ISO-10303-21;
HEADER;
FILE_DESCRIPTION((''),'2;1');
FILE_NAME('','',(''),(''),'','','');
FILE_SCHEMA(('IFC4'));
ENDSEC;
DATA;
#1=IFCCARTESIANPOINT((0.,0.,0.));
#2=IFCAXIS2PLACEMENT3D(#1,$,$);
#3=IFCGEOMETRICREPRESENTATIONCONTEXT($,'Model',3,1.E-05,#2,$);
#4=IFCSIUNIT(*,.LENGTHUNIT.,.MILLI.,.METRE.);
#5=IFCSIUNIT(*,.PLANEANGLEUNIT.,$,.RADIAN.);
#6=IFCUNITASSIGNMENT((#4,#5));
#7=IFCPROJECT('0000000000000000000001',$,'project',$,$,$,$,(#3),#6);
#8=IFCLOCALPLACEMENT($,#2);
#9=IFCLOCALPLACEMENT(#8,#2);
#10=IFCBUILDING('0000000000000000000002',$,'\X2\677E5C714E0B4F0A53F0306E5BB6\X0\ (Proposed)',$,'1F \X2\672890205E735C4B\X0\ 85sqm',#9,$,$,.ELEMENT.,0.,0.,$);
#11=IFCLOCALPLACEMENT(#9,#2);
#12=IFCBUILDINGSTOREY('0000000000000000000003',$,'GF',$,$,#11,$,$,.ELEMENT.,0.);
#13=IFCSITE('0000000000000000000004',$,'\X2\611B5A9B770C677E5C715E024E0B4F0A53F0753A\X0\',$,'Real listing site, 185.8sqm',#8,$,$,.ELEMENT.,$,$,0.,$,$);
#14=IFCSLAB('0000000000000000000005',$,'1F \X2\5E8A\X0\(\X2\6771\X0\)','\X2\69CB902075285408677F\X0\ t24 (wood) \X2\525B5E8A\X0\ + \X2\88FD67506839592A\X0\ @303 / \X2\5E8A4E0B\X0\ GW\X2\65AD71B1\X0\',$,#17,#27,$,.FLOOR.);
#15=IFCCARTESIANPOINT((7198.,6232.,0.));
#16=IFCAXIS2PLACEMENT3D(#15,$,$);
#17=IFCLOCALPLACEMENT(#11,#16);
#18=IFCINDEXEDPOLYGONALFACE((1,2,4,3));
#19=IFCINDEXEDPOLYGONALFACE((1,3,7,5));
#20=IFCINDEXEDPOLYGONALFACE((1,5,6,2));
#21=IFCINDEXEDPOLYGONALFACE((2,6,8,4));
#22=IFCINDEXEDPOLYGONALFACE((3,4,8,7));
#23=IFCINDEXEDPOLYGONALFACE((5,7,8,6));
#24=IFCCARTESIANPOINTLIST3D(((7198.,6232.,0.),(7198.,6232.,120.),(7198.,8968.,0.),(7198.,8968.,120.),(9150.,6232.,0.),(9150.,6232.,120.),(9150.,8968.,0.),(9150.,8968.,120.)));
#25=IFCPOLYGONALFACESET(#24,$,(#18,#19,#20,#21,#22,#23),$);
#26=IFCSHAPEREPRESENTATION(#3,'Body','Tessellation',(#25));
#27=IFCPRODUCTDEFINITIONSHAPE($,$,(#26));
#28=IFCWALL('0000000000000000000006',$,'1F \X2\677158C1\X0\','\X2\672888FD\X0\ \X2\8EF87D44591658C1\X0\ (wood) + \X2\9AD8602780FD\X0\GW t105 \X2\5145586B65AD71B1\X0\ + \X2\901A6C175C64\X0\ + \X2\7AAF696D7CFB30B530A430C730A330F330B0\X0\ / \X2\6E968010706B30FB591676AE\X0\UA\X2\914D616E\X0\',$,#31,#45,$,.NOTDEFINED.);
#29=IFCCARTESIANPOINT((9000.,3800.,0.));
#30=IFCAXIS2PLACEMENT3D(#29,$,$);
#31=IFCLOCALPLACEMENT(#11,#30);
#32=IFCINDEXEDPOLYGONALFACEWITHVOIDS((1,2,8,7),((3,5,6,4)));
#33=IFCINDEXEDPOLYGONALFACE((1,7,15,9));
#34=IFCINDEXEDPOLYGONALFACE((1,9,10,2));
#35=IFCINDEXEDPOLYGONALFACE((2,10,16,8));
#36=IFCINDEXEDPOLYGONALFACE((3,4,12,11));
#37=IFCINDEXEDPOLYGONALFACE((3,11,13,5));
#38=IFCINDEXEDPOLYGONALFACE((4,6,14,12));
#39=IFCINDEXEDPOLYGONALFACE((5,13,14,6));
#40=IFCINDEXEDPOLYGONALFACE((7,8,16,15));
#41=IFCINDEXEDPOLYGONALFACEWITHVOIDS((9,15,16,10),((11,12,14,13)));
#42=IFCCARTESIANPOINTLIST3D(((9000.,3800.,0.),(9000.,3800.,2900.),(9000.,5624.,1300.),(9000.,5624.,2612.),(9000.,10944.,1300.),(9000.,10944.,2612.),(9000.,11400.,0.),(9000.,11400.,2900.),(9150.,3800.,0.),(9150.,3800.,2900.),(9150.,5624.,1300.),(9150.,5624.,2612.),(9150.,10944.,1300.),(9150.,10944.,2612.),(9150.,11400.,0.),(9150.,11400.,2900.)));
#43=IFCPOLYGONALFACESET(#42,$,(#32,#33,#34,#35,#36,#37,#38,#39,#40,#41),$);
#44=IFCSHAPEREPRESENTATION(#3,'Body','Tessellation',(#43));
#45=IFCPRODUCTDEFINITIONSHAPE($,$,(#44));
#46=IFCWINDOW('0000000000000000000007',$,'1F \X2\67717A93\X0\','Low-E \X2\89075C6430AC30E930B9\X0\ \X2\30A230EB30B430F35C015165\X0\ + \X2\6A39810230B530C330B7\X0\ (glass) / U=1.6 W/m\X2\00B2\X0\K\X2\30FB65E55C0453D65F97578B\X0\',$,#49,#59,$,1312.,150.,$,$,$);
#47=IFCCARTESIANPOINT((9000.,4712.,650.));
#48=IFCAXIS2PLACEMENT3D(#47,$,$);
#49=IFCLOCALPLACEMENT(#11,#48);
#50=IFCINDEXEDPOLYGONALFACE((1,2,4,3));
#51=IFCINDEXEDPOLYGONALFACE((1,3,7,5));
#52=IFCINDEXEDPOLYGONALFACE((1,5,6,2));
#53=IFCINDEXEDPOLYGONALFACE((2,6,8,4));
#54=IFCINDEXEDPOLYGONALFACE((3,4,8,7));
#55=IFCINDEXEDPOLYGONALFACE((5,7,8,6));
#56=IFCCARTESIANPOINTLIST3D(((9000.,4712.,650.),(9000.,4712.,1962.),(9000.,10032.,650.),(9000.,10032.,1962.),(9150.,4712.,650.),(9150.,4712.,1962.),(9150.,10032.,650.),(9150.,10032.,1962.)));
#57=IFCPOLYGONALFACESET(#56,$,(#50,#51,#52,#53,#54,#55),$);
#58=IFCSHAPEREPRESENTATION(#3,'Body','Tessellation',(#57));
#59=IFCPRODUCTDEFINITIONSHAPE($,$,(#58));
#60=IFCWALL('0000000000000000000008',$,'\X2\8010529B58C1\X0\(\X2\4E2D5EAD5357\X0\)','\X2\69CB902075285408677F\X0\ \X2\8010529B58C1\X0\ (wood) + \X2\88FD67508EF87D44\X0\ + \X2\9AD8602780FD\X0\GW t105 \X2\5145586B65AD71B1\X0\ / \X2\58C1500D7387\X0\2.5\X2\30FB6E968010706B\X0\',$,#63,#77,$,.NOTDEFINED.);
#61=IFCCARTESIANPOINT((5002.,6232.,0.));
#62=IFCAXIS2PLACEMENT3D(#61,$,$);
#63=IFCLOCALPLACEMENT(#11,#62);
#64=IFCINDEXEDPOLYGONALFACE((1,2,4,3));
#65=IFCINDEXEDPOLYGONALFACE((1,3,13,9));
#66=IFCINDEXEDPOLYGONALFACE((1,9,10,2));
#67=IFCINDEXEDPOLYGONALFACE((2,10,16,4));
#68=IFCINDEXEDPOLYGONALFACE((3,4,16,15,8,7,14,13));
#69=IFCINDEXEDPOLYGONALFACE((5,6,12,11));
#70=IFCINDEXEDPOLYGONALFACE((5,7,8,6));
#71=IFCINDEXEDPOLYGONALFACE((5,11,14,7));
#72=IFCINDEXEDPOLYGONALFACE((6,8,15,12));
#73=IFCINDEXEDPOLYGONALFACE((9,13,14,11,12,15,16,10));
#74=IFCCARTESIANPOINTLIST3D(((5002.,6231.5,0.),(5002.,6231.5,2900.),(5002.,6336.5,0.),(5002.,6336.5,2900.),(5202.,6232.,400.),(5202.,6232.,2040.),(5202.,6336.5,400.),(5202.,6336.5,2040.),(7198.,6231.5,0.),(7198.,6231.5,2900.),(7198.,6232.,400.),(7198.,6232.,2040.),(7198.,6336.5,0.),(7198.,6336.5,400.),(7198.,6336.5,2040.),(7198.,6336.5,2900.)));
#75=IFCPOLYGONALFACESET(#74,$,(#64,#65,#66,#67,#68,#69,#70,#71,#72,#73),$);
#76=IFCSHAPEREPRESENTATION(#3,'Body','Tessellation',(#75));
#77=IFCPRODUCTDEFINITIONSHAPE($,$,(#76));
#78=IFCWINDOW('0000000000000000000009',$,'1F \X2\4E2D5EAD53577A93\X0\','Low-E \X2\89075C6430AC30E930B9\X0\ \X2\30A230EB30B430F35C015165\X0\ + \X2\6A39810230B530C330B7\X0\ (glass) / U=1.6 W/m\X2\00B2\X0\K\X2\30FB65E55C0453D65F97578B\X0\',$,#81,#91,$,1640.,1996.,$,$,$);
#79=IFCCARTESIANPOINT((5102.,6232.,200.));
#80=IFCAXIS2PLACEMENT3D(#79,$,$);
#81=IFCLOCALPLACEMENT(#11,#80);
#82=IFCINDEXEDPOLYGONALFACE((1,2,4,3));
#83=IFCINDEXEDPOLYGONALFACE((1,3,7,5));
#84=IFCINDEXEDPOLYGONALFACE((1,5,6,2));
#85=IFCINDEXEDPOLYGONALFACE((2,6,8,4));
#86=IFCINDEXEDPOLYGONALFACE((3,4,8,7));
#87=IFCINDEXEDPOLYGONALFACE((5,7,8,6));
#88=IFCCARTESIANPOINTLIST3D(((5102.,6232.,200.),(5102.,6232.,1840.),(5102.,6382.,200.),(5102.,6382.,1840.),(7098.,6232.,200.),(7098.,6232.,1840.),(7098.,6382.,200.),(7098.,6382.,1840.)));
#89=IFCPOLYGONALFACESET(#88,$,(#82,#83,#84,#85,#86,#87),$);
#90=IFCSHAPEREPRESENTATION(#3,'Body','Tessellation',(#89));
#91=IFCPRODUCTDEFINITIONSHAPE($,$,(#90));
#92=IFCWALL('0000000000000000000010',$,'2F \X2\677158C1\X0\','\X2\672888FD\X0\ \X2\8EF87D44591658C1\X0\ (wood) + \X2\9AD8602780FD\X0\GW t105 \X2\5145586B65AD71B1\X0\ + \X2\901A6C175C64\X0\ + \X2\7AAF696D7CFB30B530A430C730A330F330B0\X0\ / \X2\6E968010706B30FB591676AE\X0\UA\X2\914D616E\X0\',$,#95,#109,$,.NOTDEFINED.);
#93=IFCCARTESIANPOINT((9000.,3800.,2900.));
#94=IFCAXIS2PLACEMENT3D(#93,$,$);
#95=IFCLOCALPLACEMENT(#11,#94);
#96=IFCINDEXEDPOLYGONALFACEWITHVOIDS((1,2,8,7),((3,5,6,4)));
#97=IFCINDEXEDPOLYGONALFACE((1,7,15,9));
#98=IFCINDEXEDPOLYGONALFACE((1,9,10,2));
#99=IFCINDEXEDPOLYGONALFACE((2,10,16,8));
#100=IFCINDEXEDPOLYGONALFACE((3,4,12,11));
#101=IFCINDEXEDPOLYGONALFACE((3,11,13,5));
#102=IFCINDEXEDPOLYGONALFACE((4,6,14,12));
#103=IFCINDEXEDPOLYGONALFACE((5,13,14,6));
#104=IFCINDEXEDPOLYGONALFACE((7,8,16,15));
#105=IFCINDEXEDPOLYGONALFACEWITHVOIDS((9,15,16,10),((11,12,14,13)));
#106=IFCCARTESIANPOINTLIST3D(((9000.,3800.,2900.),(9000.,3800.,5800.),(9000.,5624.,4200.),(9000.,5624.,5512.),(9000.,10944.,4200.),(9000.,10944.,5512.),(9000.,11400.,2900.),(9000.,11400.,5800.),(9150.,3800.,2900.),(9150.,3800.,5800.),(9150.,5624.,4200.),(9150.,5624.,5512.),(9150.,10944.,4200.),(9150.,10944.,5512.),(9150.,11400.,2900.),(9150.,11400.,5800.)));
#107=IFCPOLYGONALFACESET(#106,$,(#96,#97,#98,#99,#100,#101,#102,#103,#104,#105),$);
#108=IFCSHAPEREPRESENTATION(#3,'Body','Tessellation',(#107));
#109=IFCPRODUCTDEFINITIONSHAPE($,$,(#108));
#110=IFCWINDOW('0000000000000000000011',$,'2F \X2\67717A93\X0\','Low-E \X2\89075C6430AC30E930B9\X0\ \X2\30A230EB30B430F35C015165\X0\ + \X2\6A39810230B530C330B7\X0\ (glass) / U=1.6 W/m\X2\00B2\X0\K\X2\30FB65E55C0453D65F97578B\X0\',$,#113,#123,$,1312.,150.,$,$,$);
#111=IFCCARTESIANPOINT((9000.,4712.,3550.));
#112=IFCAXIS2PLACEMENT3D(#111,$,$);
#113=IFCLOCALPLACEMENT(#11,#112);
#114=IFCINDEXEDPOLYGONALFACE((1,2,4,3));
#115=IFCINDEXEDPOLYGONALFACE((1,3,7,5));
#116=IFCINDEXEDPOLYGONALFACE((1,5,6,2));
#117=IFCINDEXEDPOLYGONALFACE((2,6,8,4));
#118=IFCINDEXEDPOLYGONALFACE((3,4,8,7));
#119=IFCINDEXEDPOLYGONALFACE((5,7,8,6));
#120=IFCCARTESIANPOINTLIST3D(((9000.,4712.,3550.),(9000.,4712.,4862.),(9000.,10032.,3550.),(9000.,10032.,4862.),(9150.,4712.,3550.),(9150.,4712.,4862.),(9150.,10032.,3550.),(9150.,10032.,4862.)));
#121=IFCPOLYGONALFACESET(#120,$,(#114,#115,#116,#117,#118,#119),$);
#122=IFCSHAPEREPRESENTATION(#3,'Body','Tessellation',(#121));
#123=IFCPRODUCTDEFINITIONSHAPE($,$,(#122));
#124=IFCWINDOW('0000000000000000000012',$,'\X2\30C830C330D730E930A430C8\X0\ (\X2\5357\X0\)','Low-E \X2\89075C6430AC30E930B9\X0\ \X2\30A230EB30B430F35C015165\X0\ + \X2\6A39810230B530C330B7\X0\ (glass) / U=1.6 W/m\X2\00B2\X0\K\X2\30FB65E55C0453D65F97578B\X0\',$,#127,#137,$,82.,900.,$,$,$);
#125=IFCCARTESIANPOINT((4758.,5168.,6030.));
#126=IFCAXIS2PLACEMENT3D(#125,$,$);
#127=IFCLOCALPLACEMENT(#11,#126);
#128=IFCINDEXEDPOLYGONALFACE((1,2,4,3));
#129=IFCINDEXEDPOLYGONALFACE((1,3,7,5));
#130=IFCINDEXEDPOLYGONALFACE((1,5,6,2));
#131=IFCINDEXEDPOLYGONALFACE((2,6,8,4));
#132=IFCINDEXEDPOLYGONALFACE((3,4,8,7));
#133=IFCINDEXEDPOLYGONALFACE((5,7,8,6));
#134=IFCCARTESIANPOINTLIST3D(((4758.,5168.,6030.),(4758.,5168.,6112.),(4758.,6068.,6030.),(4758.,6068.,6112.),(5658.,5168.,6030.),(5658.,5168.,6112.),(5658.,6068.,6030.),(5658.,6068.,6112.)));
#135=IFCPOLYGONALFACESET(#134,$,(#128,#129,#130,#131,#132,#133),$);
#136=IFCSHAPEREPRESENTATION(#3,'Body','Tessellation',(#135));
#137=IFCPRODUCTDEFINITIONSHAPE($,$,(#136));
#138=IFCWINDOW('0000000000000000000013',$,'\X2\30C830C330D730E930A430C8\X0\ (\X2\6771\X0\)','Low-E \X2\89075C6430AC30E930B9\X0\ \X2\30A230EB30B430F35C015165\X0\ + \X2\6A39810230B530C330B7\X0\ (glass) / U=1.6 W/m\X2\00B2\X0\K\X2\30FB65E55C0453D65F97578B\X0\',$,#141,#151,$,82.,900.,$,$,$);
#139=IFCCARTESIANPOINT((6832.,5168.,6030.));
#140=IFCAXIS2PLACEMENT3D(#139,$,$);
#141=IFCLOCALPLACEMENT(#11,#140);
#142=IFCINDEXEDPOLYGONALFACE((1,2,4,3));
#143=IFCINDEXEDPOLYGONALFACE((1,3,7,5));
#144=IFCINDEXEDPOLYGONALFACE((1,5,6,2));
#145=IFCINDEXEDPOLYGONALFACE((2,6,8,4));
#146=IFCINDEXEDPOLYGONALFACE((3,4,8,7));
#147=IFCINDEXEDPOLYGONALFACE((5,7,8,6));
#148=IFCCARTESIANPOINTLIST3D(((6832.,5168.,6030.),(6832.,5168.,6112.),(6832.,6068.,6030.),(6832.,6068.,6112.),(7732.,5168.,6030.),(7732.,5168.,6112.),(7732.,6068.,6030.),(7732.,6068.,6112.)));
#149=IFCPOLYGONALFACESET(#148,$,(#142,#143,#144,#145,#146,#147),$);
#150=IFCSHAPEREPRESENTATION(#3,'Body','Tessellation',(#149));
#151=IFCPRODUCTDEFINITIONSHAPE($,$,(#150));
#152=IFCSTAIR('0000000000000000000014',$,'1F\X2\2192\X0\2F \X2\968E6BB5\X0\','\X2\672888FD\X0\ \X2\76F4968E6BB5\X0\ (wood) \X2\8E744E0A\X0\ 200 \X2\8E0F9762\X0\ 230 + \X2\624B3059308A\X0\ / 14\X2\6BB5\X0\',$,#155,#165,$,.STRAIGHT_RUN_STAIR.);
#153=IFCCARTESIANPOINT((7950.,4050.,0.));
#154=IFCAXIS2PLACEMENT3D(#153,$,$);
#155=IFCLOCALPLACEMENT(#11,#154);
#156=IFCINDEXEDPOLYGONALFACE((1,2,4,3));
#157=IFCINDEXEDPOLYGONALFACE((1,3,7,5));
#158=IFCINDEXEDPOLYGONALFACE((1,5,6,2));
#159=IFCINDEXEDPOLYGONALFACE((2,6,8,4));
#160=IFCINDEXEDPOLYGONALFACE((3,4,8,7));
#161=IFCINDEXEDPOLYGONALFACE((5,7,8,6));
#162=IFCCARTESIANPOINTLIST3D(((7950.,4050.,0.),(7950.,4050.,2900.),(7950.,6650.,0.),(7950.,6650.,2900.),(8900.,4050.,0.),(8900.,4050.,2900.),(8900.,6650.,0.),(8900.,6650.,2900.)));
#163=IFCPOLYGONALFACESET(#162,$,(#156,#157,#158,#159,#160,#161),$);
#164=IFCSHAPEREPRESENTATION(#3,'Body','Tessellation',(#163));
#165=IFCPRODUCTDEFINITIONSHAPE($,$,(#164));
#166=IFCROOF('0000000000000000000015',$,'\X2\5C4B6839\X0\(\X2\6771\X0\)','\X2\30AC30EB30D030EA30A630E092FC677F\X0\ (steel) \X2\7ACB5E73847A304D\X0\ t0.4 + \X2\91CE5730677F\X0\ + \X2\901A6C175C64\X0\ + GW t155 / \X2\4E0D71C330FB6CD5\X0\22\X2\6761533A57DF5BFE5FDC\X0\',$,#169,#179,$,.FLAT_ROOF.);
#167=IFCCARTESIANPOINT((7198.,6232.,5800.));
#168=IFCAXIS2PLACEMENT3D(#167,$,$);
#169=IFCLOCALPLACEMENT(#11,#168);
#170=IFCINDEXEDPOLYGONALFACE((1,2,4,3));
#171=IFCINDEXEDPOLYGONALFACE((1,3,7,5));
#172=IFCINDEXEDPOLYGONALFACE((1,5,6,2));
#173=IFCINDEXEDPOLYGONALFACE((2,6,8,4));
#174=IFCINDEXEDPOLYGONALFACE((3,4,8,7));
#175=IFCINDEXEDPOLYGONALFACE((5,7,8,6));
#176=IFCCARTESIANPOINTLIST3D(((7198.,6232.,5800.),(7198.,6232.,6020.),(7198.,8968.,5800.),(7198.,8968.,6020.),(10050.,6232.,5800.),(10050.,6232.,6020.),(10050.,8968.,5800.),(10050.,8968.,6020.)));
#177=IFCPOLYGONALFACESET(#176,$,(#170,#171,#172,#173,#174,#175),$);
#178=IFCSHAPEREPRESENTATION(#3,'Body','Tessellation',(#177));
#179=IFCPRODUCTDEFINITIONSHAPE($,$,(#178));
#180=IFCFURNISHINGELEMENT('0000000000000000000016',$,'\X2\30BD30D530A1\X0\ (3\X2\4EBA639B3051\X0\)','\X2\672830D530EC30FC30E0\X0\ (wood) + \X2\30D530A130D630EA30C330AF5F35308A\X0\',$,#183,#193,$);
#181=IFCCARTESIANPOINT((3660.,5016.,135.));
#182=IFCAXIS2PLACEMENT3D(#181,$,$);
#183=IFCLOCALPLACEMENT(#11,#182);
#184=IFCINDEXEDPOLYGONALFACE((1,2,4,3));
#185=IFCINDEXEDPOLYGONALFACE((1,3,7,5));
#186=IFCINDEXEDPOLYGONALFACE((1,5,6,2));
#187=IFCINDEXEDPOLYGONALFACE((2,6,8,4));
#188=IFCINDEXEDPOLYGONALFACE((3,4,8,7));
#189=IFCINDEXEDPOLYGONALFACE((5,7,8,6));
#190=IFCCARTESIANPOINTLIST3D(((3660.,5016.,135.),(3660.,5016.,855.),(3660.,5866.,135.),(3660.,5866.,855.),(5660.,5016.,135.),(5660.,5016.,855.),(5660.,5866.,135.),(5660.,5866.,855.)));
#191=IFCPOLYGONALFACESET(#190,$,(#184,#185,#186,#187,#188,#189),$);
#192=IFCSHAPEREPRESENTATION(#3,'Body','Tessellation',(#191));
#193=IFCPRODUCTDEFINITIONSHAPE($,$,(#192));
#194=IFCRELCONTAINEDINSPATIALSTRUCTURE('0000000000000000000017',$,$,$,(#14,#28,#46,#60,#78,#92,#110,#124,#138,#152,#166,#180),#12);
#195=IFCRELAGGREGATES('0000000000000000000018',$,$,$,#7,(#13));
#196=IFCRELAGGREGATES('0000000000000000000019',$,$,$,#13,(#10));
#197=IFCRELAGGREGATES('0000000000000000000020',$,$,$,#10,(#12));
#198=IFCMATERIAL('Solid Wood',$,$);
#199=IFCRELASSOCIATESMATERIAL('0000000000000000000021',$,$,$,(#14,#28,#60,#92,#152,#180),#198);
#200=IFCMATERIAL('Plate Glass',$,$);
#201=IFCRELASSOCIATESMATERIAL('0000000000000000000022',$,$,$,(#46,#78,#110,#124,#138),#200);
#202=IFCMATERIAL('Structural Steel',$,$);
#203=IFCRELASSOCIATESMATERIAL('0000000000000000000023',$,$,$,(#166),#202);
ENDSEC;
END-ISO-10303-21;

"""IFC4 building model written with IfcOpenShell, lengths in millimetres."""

from ifc_helpers import new_model, si_unit, frame, frame_2d, origin, place, context, project, spatial, rectangle, extrude, material, element, fill, save


model = new_model("IFC4")

# Units and contexts
model_context = context("Model", 3, precision=1e-05, world=origin())
ifc_project = project(units=[si_unit("LENGTHUNIT", "METRE", prefix="MILLI"), si_unit("PLANEANGLEUNIT", "RADIAN")], contexts=[model_context])

# Site, building, storey
site_placement = place(None, origin())
site = spatial("IfcSite", under=ifc_project, at=site_placement, Name="愛媛県松山市下伊台町", ObjectType="Real listing site, 185.8sqm", CompositionType="ELEMENT", RefElevation=0.0)
building_placement = place(site_placement, origin())
building = spatial("IfcBuilding", under=site, at=building_placement, Name="松山下伊台の家 (Proposed)", ObjectType="1F 木造平屋 85sqm", CompositionType="ELEMENT", ElevationOfRefHeight=0.0, ElevationOfTerrain=0.0)
storey_placement = place(building_placement, origin())
storey = spatial("IfcBuildingStorey", under=building, at=storey_placement, Name="GF", CompositionType="ELEMENT", Elevation=0.0)

# Slab
ifc_material_1 = material(Name="Solid Wood")
slab_placement = place(storey_placement, frame((7198.0, 6232.0, 0.0)))
element("IfcSlab", 1, at=slab_placement, inside=storey, material=ifc_material_1, Name="1F 床(東)", Description="構造用合板 t24 (wood) 剛床 + 製材根太 @303 / 床下 GW断熱", PredefinedType="FLOOR", context=model_context, shape_type="SweptSolid", body=[
    extrude(rectangle(XDim=1952.0, YDim=2736.0, at=frame_2d((976.0, 1368.0))), frame((7198.0, 6232.0, 0.0)), (0.0, 0.0, 1.0), 120.0),
])

# Walls, openings, windows
wall_1_placement = place(storey_placement, frame((9000.0, 3800.0, 0.0)))
wall_1 = element("IfcWall", 2, at=wall_1_placement, inside=storey, material=ifc_material_1, Name="1F 東壁", Description="木製 軸組外壁 (wood) + 高性能GW t105 充填断熱 + 通気層 + 窯業系サイディング / 準耐火・外皮UA配慮", PredefinedType="NOTDEFINED", context=model_context, shape_type="SweptSolid", body=[
    extrude(rectangle(XDim=150.0, YDim=7600.0, at=frame_2d((75.0, 3800.0))), frame((9000.0, 3800.0, 0.0)), (0.0, 0.0, 1.0), 2900.0),
])
opening_1_placement = place(storey_placement, frame((9000.0, 4712.0, 650.0)))
opening_1 = element("IfcOpeningElement", 3, at=opening_1_placement, cuts=wall_1, PredefinedType="NOTDEFINED", context=model_context, shape_type="SweptSolid", body=[
    extrude(rectangle(XDim=150.0, YDim=5320.0, at=frame_2d((75.0, 2660.0))), frame((9000.0, 4712.0, 650.0)), (0.0, 0.0, 1.0), 1312.0),
])
ifc_material_2 = material(Name="Plate Glass")
window_1_placement = place(storey_placement, frame((9000.0, 4712.0, 650.0)))
window_1 = element("IfcWindow", 4, at=window_1_placement, inside=storey, material=ifc_material_2, Name="1F 東窓", Description="Low-E 複層ガラス アルゴン封入 + 樹脂サッシ (glass) / U=1.6 W/m²K・日射取得型", OverallHeight=1312.0, OverallWidth=150.0, context=model_context, shape_type="SweptSolid", body=[
    extrude(rectangle(XDim=150.0, YDim=5320.0, at=frame_2d((75.0, 2660.0))), frame((9000.0, 4712.0, 650.0)), (0.0, 0.0, 1.0), 1312.0),
])
fill(opening_1, window_1)
wall_2_placement = place(storey_placement, frame((5002.0, 6232.0, 0.0)))
wall_2 = element("IfcWall", 5, at=wall_2_placement, inside=storey, material=ifc_material_1, Name="耐力壁(中庭南)", Description="構造用合板 耐力壁 (wood) + 製材軸組 + 高性能GW t105 充填断熱 / 壁倍率2.5・準耐火", PredefinedType="NOTDEFINED", context=model_context, shape_type="SweptSolid", body=[
    extrude(rectangle(XDim=2196.0, YDim=105.0, at=frame_2d((1098.0, 52.0))), frame((5002.0, 6232.0, 0.0)), (0.0, 0.0, 1.0), 2900.0),
])
opening_2_placement = place(storey_placement, frame((5102.0, 6232.0, 200.0)))
opening_2 = element("IfcOpeningElement", 6, at=opening_2_placement, cuts=wall_2, PredefinedType="NOTDEFINED", context=model_context, shape_type="SweptSolid", body=[
    extrude(rectangle(XDim=1996.0, YDim=150.0, at=frame_2d((998.0, 75.0))), frame((5102.0, 6232.0, 200.0)), (0.0, 0.0, 1.0), 1640.0),
])
window_2_placement = place(storey_placement, frame((5102.0, 6232.0, 200.0)))
window_2 = element("IfcWindow", 7, at=window_2_placement, inside=storey, material=ifc_material_2, Name="1F 中庭南窓", Description="Low-E 複層ガラス アルゴン封入 + 樹脂サッシ (glass) / U=1.6 W/m²K・日射取得型", OverallHeight=1640.0, OverallWidth=1996.0, context=model_context, shape_type="SweptSolid", body=[
    extrude(rectangle(XDim=1996.0, YDim=150.0, at=frame_2d((998.0, 75.0))), frame((5102.0, 6232.0, 200.0)), (0.0, 0.0, 1.0), 1640.0),
])
fill(opening_2, window_2)

# Wall, opening, window
wall_3_placement = place(storey_placement, frame((9000.0, 3800.0, 2900.0)))
wall_3 = element("IfcWall", 8, at=wall_3_placement, inside=storey, material=ifc_material_1, Name="2F 東壁", Description="木製 軸組外壁 (wood) + 高性能GW t105 充填断熱 + 通気層 + 窯業系サイディング / 準耐火・外皮UA配慮", PredefinedType="NOTDEFINED", context=model_context, shape_type="SweptSolid", body=[
    extrude(rectangle(XDim=150.0, YDim=7600.0, at=frame_2d((75.0, 3800.0))), frame((9000.0, 3800.0, 2900.0)), (0.0, 0.0, 1.0), 2900.0),
])
opening_3_placement = place(storey_placement, frame((9000.0, 4712.0, 3550.0)))
opening_3 = element("IfcOpeningElement", 9, at=opening_3_placement, cuts=wall_3, PredefinedType="NOTDEFINED", context=model_context, shape_type="SweptSolid", body=[
    extrude(rectangle(XDim=150.0, YDim=5320.0, at=frame_2d((75.0, 2660.0))), frame((9000.0, 4712.0, 3550.0)), (0.0, 0.0, 1.0), 1312.0),
])
window_3_placement = place(storey_placement, frame((9000.0, 4712.0, 3550.0)))
window_3 = element("IfcWindow", 10, at=window_3_placement, inside=storey, material=ifc_material_2, Name="2F 東窓", Description="Low-E 複層ガラス アルゴン封入 + 樹脂サッシ (glass) / U=1.6 W/m²K・日射取得型", OverallHeight=1312.0, OverallWidth=150.0, context=model_context, shape_type="SweptSolid", body=[
    extrude(rectangle(XDim=150.0, YDim=5320.0, at=frame_2d((75.0, 2660.0))), frame((9000.0, 4712.0, 3550.0)), (0.0, 0.0, 1.0), 1312.0),
])
fill(opening_3, window_3)

# Windows
window_4_placement = place(storey_placement, frame((4758.0, 5168.0, 6030.0)))
element("IfcWindow", 11, at=window_4_placement, inside=storey, material=ifc_material_2, Name="トップライト (南)", Description="Low-E 複層ガラス アルゴン封入 + 樹脂サッシ (glass) / U=1.6 W/m²K・日射取得型", OverallHeight=82.0, OverallWidth=900.0, context=model_context, shape_type="SweptSolid", body=[
    extrude(rectangle(XDim=900.0, YDim=900.0, at=frame_2d((450.0, 450.0))), frame((4758.0, 5168.0, 6030.0)), (0.0, 0.0, 1.0), 82.0),
])
window_5_placement = place(storey_placement, frame((6832.0, 5168.0, 6030.0)))
element("IfcWindow", 12, at=window_5_placement, inside=storey, material=ifc_material_2, Name="トップライト (東)", Description="Low-E 複層ガラス アルゴン封入 + 樹脂サッシ (glass) / U=1.6 W/m²K・日射取得型", OverallHeight=82.0, OverallWidth=900.0, context=model_context, shape_type="SweptSolid", body=[
    extrude(rectangle(XDim=900.0, YDim=900.0, at=frame_2d((450.0, 450.0))), frame((6832.0, 5168.0, 6030.0)), (0.0, 0.0, 1.0), 82.0),
])

# Stair
stair_placement = place(storey_placement, frame((7950.0, 4050.0, 0.0)))
element("IfcStair", 13, at=stair_placement, inside=storey, material=ifc_material_1, Name="1F→2F 階段", Description="木製 直階段 (wood) 蹴上 200 踏面 230 + 手すり / 14段", PredefinedType="STRAIGHT_RUN_STAIR", context=model_context, shape_type="SweptSolid", body=[
    extrude(rectangle(XDim=950.0, YDim=2600.0, at=frame_2d((475.0, 1300.0))), frame((7950.0, 4050.0, 0.0)), (0.0, 0.0, 1.0), 2900.0),
])

# Roof
ifc_material_3 = material(Name="Structural Steel")
roof_placement = place(storey_placement, frame((7198.0, 6232.0, 5800.0)))
element("IfcRoof", 14, at=roof_placement, inside=storey, material=ifc_material_3, Name="屋根(東)", Description="ガルバリウム鋼板 (steel) 立平葺き t0.4 + 野地板 + 通気層 + GW t155 / 不燃・法22条区域対応", PredefinedType="FLAT_ROOF", context=model_context, shape_type="SweptSolid", body=[
    extrude(rectangle(XDim=2852.0, YDim=2736.0, at=frame_2d((1426.0, 1368.0))), frame((7198.0, 6232.0, 5800.0)), (0.0, 0.0, 1.0), 220.0),
])

# Furnishing element
furnishing_1_placement = place(storey_placement, frame((3660.0, 5016.0, 135.0)))
element("IfcFurnishingElement", 15, at=furnishing_1_placement, inside=storey, material=ifc_material_1, Name="ソファ (3人掛け)", Description="木フレーム (wood) + ファブリック張り", context=model_context, shape_type="SweptSolid", body=[
    extrude(rectangle(XDim=2000.0, YDim=850.0, at=frame_2d((1000.0, 425.0))), frame((3660.0, 5016.0, 135.0)), (0.0, 0.0, 1.0), 720.0),
])

save(model, "model.ifc")
